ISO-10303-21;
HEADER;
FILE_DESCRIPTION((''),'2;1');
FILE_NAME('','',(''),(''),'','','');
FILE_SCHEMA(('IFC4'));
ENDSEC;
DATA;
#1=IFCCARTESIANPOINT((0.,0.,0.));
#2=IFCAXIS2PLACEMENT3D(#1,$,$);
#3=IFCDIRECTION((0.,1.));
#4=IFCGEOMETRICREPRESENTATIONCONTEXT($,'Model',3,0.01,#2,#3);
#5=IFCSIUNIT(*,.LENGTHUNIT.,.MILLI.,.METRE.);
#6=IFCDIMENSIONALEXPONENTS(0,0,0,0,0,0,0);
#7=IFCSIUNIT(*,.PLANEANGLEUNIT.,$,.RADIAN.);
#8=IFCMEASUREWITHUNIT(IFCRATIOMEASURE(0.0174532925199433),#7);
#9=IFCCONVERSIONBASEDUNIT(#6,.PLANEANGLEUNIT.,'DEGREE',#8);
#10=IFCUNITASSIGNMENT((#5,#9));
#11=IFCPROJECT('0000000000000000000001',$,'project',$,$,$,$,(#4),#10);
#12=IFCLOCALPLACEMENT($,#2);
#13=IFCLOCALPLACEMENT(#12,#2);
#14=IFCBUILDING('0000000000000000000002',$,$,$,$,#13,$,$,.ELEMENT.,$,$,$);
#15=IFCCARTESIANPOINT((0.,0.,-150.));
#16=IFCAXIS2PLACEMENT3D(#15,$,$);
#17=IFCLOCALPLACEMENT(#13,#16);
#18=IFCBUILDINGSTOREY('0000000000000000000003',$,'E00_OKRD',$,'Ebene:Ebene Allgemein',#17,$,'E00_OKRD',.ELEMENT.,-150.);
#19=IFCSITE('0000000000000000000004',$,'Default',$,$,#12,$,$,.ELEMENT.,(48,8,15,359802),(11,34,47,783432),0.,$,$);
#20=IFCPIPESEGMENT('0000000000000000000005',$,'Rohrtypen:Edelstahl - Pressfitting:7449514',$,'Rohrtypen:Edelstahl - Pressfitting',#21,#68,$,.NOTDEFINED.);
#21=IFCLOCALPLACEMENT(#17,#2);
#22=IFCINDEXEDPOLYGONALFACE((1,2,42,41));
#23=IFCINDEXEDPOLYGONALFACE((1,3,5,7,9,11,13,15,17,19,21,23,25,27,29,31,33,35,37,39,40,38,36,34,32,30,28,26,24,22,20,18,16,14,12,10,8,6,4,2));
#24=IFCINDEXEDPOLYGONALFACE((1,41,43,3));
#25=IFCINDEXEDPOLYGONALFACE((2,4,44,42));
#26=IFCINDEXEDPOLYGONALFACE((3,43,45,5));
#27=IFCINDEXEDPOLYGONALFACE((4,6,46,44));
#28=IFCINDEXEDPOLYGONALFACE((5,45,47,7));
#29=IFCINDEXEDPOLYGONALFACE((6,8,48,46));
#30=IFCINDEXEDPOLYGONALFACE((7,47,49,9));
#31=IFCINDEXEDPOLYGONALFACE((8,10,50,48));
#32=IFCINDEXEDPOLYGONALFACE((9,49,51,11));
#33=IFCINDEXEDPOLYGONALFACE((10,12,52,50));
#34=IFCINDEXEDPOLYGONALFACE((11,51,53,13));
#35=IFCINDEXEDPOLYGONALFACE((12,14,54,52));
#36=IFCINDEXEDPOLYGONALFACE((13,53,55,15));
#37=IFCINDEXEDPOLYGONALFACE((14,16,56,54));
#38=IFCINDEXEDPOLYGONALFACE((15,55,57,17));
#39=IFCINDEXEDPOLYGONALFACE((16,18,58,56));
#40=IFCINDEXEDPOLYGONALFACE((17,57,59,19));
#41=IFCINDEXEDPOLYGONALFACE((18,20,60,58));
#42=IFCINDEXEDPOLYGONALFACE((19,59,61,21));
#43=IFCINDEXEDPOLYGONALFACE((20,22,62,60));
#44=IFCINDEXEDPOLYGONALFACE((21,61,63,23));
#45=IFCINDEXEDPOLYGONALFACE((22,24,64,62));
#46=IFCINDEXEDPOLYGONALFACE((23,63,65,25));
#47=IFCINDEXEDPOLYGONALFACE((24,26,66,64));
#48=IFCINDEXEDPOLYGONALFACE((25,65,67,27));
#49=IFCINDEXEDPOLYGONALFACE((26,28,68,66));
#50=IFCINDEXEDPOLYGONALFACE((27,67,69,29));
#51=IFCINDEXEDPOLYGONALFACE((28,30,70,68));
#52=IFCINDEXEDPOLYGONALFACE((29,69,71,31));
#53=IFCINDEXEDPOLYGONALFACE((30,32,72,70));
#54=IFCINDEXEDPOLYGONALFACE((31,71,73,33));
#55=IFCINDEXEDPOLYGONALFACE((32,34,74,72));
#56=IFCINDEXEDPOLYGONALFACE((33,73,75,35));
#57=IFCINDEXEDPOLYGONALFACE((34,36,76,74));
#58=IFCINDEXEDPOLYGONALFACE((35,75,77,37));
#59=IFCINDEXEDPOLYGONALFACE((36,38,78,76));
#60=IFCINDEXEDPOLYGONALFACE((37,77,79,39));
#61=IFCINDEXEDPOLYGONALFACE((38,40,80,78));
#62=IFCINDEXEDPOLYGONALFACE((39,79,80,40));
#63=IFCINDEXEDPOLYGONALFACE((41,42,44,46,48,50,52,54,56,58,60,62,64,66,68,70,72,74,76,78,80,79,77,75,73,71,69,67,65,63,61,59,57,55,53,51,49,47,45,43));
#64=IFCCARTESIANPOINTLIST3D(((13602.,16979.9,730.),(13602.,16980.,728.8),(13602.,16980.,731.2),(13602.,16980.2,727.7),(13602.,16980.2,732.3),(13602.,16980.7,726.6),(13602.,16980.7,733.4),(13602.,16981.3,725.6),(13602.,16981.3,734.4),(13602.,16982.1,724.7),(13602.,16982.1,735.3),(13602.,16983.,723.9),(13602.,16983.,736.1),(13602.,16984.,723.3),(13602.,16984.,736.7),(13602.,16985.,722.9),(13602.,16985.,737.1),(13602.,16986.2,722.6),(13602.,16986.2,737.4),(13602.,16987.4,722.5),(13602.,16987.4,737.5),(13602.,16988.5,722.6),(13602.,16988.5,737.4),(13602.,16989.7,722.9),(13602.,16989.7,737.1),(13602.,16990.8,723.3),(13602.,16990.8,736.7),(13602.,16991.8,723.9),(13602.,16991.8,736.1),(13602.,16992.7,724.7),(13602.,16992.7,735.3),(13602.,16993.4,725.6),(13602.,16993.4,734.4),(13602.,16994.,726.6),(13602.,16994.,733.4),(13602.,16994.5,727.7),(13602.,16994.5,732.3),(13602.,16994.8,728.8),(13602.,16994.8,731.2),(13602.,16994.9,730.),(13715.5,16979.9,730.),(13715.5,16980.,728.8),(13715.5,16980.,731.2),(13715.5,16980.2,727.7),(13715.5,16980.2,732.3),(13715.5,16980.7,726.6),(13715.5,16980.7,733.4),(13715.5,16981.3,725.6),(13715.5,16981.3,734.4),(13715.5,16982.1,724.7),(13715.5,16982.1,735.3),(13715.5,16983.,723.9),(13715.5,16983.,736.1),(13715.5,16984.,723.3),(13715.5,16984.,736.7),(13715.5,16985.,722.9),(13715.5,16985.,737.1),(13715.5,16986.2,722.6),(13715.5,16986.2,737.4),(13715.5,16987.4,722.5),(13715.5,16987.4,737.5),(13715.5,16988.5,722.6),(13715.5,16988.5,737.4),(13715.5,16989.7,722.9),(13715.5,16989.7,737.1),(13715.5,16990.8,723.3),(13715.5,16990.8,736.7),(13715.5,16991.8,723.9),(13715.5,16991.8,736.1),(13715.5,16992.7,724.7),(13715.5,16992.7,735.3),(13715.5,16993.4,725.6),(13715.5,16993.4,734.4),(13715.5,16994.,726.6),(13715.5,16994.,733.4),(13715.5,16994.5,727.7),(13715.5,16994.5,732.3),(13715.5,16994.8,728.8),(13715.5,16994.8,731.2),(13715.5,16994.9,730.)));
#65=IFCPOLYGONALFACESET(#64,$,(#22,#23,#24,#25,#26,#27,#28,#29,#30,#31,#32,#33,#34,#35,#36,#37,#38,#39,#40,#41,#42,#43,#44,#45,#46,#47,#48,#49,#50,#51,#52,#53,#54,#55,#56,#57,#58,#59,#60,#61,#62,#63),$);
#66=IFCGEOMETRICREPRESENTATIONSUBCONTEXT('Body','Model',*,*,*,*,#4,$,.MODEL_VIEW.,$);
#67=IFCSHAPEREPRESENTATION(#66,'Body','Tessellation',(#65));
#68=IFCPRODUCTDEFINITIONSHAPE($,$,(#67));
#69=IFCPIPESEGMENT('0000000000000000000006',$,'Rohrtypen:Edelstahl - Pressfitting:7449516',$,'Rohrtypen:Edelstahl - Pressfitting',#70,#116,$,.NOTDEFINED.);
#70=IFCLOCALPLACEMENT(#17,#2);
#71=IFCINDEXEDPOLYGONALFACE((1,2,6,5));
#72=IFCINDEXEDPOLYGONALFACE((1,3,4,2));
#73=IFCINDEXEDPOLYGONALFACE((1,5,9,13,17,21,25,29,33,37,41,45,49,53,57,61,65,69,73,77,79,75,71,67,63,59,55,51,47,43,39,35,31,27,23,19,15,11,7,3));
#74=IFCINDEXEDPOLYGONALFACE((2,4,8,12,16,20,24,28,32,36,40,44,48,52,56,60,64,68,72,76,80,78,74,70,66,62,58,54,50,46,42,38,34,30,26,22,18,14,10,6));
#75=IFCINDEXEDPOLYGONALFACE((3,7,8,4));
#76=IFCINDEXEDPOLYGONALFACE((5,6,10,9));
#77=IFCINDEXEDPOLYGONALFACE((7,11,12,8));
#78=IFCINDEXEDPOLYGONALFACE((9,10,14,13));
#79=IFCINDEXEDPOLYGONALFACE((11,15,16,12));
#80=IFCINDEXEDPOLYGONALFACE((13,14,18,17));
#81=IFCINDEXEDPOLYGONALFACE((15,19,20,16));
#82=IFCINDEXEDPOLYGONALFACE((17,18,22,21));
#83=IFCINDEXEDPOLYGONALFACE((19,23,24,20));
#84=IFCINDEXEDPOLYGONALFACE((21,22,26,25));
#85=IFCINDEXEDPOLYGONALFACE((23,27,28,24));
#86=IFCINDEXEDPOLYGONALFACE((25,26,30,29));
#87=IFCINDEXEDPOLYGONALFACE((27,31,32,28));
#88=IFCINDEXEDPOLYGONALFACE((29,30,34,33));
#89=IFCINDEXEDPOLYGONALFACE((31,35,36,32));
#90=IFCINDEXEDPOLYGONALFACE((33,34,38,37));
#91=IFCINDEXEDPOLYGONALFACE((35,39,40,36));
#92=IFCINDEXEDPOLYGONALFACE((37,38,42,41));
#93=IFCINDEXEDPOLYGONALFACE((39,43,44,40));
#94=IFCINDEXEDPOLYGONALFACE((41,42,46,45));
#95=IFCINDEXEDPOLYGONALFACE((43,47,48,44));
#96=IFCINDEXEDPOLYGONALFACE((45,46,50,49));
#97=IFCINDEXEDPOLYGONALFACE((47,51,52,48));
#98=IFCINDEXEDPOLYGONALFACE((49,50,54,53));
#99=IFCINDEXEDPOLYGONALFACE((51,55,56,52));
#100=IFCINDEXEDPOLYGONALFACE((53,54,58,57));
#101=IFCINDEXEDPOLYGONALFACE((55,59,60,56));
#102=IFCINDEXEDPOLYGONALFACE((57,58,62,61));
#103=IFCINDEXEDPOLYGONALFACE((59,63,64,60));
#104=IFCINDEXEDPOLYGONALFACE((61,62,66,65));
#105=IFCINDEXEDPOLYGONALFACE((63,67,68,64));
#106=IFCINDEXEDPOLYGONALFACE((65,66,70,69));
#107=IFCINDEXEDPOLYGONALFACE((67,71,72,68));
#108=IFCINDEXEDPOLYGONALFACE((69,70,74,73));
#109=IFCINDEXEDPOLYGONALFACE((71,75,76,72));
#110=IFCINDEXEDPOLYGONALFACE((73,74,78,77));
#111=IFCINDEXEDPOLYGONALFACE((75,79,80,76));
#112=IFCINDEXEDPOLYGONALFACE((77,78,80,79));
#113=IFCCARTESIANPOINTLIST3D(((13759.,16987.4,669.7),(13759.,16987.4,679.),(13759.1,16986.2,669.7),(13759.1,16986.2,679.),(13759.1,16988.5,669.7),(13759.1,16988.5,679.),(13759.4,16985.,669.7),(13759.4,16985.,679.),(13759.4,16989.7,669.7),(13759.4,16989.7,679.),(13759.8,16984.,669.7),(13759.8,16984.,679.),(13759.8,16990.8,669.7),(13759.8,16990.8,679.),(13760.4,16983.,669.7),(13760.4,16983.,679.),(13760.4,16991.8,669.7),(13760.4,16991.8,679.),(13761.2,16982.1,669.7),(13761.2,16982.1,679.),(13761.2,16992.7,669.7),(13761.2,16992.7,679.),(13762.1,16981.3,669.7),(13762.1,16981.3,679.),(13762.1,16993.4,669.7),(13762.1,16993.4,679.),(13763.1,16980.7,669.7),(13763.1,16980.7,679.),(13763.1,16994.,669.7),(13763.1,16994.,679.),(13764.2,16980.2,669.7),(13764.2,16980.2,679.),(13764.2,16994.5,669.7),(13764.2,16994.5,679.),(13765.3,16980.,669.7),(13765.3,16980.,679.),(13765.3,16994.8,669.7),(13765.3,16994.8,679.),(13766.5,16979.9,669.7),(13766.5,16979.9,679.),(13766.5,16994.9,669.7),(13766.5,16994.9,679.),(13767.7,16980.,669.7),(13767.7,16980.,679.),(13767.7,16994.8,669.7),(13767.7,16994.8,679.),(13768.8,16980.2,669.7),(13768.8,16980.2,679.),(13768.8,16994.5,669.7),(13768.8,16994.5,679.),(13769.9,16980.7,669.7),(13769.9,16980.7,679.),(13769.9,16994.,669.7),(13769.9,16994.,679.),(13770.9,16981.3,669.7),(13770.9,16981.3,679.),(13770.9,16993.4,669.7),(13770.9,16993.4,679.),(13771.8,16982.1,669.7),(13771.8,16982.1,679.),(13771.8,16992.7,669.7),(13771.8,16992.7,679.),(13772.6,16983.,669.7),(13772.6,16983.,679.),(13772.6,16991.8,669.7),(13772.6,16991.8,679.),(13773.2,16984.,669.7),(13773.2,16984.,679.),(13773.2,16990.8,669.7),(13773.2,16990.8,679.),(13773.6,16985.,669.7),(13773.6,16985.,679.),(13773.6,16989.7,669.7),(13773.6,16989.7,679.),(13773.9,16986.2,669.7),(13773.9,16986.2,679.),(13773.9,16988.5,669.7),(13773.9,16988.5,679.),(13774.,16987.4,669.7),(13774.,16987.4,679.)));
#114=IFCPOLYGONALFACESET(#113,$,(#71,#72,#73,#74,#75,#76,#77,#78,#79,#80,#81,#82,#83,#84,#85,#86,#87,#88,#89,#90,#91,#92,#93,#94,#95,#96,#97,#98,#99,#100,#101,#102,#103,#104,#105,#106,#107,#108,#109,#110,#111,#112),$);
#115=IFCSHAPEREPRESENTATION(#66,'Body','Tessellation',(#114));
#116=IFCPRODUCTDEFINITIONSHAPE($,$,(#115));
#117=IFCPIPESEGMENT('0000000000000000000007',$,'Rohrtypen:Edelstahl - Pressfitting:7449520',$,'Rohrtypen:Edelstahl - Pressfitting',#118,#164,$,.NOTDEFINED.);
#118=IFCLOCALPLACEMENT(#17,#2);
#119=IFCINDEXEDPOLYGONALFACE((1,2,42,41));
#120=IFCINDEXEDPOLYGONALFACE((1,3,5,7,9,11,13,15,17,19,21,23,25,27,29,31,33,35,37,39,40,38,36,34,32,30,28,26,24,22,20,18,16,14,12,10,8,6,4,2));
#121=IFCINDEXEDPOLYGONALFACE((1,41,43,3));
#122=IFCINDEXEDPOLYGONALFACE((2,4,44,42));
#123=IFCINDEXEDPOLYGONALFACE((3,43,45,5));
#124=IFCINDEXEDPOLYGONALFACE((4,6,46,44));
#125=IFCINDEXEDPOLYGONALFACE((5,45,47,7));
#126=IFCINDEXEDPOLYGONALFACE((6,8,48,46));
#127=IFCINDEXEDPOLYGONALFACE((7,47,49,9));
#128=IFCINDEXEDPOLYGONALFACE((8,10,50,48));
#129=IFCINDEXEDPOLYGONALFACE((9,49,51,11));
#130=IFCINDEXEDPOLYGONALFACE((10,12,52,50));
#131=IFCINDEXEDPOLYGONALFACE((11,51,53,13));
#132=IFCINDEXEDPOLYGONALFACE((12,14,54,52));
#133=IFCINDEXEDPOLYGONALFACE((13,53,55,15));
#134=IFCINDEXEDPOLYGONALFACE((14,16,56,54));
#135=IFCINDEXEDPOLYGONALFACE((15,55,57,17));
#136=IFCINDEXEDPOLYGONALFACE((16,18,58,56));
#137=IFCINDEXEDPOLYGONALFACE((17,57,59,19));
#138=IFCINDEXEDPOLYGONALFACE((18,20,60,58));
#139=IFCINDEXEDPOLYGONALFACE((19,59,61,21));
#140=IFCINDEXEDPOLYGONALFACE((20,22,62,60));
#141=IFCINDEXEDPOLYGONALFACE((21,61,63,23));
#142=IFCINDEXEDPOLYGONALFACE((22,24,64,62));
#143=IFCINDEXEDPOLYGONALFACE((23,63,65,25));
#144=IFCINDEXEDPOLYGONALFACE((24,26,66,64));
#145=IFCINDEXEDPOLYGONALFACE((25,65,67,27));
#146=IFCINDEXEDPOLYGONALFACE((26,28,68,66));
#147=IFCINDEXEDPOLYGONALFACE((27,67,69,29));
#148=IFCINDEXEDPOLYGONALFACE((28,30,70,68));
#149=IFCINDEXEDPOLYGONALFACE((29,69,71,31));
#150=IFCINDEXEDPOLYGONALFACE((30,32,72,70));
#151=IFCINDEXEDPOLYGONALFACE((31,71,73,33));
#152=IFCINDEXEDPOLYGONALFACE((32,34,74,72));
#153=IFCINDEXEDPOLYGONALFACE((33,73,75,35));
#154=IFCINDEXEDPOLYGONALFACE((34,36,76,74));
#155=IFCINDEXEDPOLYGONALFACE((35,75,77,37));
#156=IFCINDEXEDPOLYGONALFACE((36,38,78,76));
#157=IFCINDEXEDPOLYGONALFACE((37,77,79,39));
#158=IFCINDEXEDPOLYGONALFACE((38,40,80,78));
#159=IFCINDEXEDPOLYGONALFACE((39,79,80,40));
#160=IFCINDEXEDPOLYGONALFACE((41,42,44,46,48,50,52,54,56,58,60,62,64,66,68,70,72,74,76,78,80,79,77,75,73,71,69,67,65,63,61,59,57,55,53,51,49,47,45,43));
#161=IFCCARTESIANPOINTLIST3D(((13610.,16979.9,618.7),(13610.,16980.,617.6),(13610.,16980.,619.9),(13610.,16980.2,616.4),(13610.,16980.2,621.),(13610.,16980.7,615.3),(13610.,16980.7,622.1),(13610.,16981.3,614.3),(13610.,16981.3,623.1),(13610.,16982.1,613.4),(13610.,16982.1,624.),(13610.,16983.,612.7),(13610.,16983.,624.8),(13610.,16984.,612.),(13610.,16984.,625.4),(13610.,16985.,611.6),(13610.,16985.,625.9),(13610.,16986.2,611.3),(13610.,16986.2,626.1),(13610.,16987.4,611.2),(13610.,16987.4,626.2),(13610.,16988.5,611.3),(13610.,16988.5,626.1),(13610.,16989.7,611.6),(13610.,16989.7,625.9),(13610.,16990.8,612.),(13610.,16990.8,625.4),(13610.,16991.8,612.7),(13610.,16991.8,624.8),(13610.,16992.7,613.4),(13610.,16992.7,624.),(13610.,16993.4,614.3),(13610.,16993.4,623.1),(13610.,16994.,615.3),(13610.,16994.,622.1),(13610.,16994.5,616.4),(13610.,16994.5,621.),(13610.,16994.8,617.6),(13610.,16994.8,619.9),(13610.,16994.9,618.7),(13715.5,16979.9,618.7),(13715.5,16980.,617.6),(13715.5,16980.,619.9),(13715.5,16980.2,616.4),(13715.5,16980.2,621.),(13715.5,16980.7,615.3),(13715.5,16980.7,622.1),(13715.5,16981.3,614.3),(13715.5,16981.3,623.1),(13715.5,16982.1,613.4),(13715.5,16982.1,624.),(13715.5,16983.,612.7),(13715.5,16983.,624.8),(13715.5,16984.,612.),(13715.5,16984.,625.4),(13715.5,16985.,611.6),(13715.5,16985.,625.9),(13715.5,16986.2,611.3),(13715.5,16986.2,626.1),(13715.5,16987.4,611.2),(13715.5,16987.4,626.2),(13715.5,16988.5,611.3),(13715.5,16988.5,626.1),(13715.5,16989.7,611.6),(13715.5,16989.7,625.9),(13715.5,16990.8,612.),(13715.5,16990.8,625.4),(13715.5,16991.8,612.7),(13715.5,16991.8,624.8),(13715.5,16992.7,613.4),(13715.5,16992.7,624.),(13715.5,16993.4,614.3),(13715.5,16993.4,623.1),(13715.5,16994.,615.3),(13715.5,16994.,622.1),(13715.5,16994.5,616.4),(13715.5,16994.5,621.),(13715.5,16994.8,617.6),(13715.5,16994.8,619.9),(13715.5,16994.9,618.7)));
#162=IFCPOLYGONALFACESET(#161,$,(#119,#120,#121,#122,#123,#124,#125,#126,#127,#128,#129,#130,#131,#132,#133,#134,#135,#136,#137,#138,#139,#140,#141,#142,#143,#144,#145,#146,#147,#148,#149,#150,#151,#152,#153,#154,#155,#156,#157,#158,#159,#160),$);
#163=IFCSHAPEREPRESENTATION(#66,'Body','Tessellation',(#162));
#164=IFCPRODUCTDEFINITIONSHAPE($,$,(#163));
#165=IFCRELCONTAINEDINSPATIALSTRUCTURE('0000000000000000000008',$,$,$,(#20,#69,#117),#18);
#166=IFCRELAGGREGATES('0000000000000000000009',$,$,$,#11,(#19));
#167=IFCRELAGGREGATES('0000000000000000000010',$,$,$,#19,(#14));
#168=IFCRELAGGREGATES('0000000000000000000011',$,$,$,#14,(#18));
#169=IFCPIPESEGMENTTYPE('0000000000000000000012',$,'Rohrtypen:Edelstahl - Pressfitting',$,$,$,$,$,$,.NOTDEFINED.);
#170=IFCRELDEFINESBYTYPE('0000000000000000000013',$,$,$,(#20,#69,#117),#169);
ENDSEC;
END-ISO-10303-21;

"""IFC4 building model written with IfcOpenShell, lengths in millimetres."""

from ifc_helpers import new_model, entity, si_unit, converted_unit, direction, frame, origin, place, context, subcontext, project, spatial, indexed_curve, outline, extrude, type_object, element, save


model = new_model("IFC4")

# Units and contexts
model_context = context("Model", 3, precision=0.01, world=origin(), true_north=direction((0.0, 1.0)))
body_context = subcontext(model_context, "Body", "Model", "MODEL_VIEW")
ifc_project = project(units=[si_unit("LENGTHUNIT", "METRE", prefix="MILLI"), converted_unit("PLANEANGLEUNIT", "DEGREE", entity("IfcRatioMeasure", 0.0174532925199433), si_unit("PLANEANGLEUNIT", "RADIAN"), dimensions=[0, 0, 0, 0, 0, 0, 0])], contexts=[model_context])

# Site, building, storey
site_placement = place(None, origin())
site = spatial("IfcSite", under=ifc_project, at=site_placement, Name="Default", CompositionType="ELEMENT", RefLatitude=(48, 8, 15, 359802), RefLongitude=(11, 34, 47, 783432), RefElevation=0.0)
building_placement = place(site_placement, origin())
building = spatial("IfcBuilding", under=site, at=building_placement, CompositionType="ELEMENT")
storey_placement = place(building_placement, frame((0.0, 0.0, -150.0)))
storey = spatial("IfcBuildingStorey", under=building, at=storey_placement, Name="E00_OKRD", ObjectType="Ebene:Ebene Allgemein", LongName="E00_OKRD", CompositionType="ELEMENT", Elevation=-150.0)

# Pipe segments
pipe_segment_type_1 = type_object("IfcPipeSegmentType", Name="Rohrtypen:Edelstahl - Pressfitting", PredefinedType="NOTDEFINED")
pipe_segment_1_placement = place(storey_placement, origin())
element("IfcPipeSegment", 1, at=pipe_segment_1_placement, inside=storey, type_object=pipe_segment_type_1, Name="Rohrtypen:Edelstahl - Pressfitting:7449514", ObjectType="Rohrtypen:Edelstahl - Pressfitting", PredefinedType="NOTDEFINED", context=body_context, shape_type="SweptSolid", body=[
    extrude(outline(indexed_curve([(7.5, 0.0), (7.4, 1.2), (7.1, 2.3), (6.7, 3.4), (6.1, 4.4), (5.3, 5.3), (4.4, 6.1), (3.4, 6.7), (2.3, 7.1), (1.2, 7.4), (0.0, 7.5), (-1.2, 7.4), (-2.3, 7.1), (-3.4, 6.7), (-4.4, 6.1), (-5.3, 5.3), (-6.1, 4.4), (-6.7, 3.4), (-7.1, 2.3), (-7.4, 1.2), (-7.5, 0.0), (-7.4, -1.2), (-7.1, -2.3), (-6.7, -3.4), (-6.1, -4.4), (-5.3, -5.3), (-4.4, -6.1), (-3.4, -6.7), (-2.3, -7.1), (-1.2, -7.4), (0.0, -7.5), (1.2, -7.4), (2.3, -7.1), (3.4, -6.7), (4.4, -6.1), (5.3, -5.3), (6.1, -4.4), (6.7, -3.4), (7.1, -2.3), (7.4, -1.2), (7.5, 0.0)], self_intersect=False)), frame((13602.0, 16987.4, 730.0), z_axis=(1.0, 0.0, 0.0), x_axis=(0.0, -1.0, 0.0)), (0.0, 0.0, 1.0), 113.6),
])
pipe_segment_2_placement = place(storey_placement, origin())
element("IfcPipeSegment", 2, at=pipe_segment_2_placement, inside=storey, type_object=pipe_segment_type_1, Name="Rohrtypen:Edelstahl - Pressfitting:7449516", ObjectType="Rohrtypen:Edelstahl - Pressfitting", PredefinedType="NOTDEFINED", context=body_context, shape_type="SweptSolid", body=[
    extrude(outline(indexed_curve([(7.5, 0.0), (7.4, 1.2), (7.1, 2.3), (6.7, 3.4), (6.1, 4.4), (5.3, 5.3), (4.4, 6.1), (3.4, 6.7), (2.3, 7.1), (1.2, 7.4), (0.0, 7.5), (-1.2, 7.4), (-2.3, 7.1), (-3.4, 6.7), (-4.4, 6.1), (-5.3, 5.3), (-6.1, 4.4), (-6.7, 3.4), (-7.1, 2.3), (-7.4, 1.2), (-7.5, 0.0), (-7.4, -1.2), (-7.1, -2.3), (-6.7, -3.4), (-6.1, -4.4), (-5.3, -5.3), (-4.4, -6.1), (-3.4, -6.7), (-2.3, -7.1), (-1.2, -7.4), (0.0, -7.5), (1.2, -7.4), (2.3, -7.1), (3.4, -6.7), (4.4, -6.1), (5.3, -5.3), (6.1, -4.4), (6.7, -3.4), (7.1, -2.3), (7.4, -1.2), (7.5, 0.0)], self_intersect=False)), frame((13766.5, 16987.4, 669.7)), (0.0, 0.0, 1.0), 9.3),
])
pipe_segment_3_placement = place(storey_placement, origin())
element("IfcPipeSegment", 3, at=pipe_segment_3_placement, inside=storey, type_object=pipe_segment_type_1, Name="Rohrtypen:Edelstahl - Pressfitting:7449520", ObjectType="Rohrtypen:Edelstahl - Pressfitting", PredefinedType="NOTDEFINED", context=body_context, shape_type="SweptSolid", body=[
    extrude(outline(indexed_curve([(7.5, 0.0), (7.4, 1.2), (7.1, 2.3), (6.7, 3.4), (6.1, 4.4), (5.3, 5.3), (4.4, 6.1), (3.4, 6.7), (2.3, 7.1), (1.2, 7.4), (0.0, 7.5), (-1.2, 7.4), (-2.3, 7.1), (-3.4, 6.7), (-4.4, 6.1), (-5.3, 5.3), (-6.1, 4.4), (-6.7, 3.4), (-7.1, 2.3), (-7.4, 1.2), (-7.5, 0.0), (-7.4, -1.2), (-7.1, -2.3), (-6.7, -3.4), (-6.1, -4.4), (-5.3, -5.3), (-4.4, -6.1), (-3.4, -6.7), (-2.3, -7.1), (-1.2, -7.4), (0.0, -7.5), (1.2, -7.4), (2.3, -7.1), (3.4, -6.7), (4.4, -6.1), (5.3, -5.3), (6.1, -4.4), (6.7, -3.4), (7.1, -2.3), (7.4, -1.2), (7.5, 0.0)], self_intersect=False)), frame((13610.0, 16987.4, 618.7), z_axis=(1.0, 0.0, 0.0), x_axis=(0.0, 1.0, 0.0)), (0.0, 0.0, 1.0), 105.6),
])

save(model, "model.ifc")
